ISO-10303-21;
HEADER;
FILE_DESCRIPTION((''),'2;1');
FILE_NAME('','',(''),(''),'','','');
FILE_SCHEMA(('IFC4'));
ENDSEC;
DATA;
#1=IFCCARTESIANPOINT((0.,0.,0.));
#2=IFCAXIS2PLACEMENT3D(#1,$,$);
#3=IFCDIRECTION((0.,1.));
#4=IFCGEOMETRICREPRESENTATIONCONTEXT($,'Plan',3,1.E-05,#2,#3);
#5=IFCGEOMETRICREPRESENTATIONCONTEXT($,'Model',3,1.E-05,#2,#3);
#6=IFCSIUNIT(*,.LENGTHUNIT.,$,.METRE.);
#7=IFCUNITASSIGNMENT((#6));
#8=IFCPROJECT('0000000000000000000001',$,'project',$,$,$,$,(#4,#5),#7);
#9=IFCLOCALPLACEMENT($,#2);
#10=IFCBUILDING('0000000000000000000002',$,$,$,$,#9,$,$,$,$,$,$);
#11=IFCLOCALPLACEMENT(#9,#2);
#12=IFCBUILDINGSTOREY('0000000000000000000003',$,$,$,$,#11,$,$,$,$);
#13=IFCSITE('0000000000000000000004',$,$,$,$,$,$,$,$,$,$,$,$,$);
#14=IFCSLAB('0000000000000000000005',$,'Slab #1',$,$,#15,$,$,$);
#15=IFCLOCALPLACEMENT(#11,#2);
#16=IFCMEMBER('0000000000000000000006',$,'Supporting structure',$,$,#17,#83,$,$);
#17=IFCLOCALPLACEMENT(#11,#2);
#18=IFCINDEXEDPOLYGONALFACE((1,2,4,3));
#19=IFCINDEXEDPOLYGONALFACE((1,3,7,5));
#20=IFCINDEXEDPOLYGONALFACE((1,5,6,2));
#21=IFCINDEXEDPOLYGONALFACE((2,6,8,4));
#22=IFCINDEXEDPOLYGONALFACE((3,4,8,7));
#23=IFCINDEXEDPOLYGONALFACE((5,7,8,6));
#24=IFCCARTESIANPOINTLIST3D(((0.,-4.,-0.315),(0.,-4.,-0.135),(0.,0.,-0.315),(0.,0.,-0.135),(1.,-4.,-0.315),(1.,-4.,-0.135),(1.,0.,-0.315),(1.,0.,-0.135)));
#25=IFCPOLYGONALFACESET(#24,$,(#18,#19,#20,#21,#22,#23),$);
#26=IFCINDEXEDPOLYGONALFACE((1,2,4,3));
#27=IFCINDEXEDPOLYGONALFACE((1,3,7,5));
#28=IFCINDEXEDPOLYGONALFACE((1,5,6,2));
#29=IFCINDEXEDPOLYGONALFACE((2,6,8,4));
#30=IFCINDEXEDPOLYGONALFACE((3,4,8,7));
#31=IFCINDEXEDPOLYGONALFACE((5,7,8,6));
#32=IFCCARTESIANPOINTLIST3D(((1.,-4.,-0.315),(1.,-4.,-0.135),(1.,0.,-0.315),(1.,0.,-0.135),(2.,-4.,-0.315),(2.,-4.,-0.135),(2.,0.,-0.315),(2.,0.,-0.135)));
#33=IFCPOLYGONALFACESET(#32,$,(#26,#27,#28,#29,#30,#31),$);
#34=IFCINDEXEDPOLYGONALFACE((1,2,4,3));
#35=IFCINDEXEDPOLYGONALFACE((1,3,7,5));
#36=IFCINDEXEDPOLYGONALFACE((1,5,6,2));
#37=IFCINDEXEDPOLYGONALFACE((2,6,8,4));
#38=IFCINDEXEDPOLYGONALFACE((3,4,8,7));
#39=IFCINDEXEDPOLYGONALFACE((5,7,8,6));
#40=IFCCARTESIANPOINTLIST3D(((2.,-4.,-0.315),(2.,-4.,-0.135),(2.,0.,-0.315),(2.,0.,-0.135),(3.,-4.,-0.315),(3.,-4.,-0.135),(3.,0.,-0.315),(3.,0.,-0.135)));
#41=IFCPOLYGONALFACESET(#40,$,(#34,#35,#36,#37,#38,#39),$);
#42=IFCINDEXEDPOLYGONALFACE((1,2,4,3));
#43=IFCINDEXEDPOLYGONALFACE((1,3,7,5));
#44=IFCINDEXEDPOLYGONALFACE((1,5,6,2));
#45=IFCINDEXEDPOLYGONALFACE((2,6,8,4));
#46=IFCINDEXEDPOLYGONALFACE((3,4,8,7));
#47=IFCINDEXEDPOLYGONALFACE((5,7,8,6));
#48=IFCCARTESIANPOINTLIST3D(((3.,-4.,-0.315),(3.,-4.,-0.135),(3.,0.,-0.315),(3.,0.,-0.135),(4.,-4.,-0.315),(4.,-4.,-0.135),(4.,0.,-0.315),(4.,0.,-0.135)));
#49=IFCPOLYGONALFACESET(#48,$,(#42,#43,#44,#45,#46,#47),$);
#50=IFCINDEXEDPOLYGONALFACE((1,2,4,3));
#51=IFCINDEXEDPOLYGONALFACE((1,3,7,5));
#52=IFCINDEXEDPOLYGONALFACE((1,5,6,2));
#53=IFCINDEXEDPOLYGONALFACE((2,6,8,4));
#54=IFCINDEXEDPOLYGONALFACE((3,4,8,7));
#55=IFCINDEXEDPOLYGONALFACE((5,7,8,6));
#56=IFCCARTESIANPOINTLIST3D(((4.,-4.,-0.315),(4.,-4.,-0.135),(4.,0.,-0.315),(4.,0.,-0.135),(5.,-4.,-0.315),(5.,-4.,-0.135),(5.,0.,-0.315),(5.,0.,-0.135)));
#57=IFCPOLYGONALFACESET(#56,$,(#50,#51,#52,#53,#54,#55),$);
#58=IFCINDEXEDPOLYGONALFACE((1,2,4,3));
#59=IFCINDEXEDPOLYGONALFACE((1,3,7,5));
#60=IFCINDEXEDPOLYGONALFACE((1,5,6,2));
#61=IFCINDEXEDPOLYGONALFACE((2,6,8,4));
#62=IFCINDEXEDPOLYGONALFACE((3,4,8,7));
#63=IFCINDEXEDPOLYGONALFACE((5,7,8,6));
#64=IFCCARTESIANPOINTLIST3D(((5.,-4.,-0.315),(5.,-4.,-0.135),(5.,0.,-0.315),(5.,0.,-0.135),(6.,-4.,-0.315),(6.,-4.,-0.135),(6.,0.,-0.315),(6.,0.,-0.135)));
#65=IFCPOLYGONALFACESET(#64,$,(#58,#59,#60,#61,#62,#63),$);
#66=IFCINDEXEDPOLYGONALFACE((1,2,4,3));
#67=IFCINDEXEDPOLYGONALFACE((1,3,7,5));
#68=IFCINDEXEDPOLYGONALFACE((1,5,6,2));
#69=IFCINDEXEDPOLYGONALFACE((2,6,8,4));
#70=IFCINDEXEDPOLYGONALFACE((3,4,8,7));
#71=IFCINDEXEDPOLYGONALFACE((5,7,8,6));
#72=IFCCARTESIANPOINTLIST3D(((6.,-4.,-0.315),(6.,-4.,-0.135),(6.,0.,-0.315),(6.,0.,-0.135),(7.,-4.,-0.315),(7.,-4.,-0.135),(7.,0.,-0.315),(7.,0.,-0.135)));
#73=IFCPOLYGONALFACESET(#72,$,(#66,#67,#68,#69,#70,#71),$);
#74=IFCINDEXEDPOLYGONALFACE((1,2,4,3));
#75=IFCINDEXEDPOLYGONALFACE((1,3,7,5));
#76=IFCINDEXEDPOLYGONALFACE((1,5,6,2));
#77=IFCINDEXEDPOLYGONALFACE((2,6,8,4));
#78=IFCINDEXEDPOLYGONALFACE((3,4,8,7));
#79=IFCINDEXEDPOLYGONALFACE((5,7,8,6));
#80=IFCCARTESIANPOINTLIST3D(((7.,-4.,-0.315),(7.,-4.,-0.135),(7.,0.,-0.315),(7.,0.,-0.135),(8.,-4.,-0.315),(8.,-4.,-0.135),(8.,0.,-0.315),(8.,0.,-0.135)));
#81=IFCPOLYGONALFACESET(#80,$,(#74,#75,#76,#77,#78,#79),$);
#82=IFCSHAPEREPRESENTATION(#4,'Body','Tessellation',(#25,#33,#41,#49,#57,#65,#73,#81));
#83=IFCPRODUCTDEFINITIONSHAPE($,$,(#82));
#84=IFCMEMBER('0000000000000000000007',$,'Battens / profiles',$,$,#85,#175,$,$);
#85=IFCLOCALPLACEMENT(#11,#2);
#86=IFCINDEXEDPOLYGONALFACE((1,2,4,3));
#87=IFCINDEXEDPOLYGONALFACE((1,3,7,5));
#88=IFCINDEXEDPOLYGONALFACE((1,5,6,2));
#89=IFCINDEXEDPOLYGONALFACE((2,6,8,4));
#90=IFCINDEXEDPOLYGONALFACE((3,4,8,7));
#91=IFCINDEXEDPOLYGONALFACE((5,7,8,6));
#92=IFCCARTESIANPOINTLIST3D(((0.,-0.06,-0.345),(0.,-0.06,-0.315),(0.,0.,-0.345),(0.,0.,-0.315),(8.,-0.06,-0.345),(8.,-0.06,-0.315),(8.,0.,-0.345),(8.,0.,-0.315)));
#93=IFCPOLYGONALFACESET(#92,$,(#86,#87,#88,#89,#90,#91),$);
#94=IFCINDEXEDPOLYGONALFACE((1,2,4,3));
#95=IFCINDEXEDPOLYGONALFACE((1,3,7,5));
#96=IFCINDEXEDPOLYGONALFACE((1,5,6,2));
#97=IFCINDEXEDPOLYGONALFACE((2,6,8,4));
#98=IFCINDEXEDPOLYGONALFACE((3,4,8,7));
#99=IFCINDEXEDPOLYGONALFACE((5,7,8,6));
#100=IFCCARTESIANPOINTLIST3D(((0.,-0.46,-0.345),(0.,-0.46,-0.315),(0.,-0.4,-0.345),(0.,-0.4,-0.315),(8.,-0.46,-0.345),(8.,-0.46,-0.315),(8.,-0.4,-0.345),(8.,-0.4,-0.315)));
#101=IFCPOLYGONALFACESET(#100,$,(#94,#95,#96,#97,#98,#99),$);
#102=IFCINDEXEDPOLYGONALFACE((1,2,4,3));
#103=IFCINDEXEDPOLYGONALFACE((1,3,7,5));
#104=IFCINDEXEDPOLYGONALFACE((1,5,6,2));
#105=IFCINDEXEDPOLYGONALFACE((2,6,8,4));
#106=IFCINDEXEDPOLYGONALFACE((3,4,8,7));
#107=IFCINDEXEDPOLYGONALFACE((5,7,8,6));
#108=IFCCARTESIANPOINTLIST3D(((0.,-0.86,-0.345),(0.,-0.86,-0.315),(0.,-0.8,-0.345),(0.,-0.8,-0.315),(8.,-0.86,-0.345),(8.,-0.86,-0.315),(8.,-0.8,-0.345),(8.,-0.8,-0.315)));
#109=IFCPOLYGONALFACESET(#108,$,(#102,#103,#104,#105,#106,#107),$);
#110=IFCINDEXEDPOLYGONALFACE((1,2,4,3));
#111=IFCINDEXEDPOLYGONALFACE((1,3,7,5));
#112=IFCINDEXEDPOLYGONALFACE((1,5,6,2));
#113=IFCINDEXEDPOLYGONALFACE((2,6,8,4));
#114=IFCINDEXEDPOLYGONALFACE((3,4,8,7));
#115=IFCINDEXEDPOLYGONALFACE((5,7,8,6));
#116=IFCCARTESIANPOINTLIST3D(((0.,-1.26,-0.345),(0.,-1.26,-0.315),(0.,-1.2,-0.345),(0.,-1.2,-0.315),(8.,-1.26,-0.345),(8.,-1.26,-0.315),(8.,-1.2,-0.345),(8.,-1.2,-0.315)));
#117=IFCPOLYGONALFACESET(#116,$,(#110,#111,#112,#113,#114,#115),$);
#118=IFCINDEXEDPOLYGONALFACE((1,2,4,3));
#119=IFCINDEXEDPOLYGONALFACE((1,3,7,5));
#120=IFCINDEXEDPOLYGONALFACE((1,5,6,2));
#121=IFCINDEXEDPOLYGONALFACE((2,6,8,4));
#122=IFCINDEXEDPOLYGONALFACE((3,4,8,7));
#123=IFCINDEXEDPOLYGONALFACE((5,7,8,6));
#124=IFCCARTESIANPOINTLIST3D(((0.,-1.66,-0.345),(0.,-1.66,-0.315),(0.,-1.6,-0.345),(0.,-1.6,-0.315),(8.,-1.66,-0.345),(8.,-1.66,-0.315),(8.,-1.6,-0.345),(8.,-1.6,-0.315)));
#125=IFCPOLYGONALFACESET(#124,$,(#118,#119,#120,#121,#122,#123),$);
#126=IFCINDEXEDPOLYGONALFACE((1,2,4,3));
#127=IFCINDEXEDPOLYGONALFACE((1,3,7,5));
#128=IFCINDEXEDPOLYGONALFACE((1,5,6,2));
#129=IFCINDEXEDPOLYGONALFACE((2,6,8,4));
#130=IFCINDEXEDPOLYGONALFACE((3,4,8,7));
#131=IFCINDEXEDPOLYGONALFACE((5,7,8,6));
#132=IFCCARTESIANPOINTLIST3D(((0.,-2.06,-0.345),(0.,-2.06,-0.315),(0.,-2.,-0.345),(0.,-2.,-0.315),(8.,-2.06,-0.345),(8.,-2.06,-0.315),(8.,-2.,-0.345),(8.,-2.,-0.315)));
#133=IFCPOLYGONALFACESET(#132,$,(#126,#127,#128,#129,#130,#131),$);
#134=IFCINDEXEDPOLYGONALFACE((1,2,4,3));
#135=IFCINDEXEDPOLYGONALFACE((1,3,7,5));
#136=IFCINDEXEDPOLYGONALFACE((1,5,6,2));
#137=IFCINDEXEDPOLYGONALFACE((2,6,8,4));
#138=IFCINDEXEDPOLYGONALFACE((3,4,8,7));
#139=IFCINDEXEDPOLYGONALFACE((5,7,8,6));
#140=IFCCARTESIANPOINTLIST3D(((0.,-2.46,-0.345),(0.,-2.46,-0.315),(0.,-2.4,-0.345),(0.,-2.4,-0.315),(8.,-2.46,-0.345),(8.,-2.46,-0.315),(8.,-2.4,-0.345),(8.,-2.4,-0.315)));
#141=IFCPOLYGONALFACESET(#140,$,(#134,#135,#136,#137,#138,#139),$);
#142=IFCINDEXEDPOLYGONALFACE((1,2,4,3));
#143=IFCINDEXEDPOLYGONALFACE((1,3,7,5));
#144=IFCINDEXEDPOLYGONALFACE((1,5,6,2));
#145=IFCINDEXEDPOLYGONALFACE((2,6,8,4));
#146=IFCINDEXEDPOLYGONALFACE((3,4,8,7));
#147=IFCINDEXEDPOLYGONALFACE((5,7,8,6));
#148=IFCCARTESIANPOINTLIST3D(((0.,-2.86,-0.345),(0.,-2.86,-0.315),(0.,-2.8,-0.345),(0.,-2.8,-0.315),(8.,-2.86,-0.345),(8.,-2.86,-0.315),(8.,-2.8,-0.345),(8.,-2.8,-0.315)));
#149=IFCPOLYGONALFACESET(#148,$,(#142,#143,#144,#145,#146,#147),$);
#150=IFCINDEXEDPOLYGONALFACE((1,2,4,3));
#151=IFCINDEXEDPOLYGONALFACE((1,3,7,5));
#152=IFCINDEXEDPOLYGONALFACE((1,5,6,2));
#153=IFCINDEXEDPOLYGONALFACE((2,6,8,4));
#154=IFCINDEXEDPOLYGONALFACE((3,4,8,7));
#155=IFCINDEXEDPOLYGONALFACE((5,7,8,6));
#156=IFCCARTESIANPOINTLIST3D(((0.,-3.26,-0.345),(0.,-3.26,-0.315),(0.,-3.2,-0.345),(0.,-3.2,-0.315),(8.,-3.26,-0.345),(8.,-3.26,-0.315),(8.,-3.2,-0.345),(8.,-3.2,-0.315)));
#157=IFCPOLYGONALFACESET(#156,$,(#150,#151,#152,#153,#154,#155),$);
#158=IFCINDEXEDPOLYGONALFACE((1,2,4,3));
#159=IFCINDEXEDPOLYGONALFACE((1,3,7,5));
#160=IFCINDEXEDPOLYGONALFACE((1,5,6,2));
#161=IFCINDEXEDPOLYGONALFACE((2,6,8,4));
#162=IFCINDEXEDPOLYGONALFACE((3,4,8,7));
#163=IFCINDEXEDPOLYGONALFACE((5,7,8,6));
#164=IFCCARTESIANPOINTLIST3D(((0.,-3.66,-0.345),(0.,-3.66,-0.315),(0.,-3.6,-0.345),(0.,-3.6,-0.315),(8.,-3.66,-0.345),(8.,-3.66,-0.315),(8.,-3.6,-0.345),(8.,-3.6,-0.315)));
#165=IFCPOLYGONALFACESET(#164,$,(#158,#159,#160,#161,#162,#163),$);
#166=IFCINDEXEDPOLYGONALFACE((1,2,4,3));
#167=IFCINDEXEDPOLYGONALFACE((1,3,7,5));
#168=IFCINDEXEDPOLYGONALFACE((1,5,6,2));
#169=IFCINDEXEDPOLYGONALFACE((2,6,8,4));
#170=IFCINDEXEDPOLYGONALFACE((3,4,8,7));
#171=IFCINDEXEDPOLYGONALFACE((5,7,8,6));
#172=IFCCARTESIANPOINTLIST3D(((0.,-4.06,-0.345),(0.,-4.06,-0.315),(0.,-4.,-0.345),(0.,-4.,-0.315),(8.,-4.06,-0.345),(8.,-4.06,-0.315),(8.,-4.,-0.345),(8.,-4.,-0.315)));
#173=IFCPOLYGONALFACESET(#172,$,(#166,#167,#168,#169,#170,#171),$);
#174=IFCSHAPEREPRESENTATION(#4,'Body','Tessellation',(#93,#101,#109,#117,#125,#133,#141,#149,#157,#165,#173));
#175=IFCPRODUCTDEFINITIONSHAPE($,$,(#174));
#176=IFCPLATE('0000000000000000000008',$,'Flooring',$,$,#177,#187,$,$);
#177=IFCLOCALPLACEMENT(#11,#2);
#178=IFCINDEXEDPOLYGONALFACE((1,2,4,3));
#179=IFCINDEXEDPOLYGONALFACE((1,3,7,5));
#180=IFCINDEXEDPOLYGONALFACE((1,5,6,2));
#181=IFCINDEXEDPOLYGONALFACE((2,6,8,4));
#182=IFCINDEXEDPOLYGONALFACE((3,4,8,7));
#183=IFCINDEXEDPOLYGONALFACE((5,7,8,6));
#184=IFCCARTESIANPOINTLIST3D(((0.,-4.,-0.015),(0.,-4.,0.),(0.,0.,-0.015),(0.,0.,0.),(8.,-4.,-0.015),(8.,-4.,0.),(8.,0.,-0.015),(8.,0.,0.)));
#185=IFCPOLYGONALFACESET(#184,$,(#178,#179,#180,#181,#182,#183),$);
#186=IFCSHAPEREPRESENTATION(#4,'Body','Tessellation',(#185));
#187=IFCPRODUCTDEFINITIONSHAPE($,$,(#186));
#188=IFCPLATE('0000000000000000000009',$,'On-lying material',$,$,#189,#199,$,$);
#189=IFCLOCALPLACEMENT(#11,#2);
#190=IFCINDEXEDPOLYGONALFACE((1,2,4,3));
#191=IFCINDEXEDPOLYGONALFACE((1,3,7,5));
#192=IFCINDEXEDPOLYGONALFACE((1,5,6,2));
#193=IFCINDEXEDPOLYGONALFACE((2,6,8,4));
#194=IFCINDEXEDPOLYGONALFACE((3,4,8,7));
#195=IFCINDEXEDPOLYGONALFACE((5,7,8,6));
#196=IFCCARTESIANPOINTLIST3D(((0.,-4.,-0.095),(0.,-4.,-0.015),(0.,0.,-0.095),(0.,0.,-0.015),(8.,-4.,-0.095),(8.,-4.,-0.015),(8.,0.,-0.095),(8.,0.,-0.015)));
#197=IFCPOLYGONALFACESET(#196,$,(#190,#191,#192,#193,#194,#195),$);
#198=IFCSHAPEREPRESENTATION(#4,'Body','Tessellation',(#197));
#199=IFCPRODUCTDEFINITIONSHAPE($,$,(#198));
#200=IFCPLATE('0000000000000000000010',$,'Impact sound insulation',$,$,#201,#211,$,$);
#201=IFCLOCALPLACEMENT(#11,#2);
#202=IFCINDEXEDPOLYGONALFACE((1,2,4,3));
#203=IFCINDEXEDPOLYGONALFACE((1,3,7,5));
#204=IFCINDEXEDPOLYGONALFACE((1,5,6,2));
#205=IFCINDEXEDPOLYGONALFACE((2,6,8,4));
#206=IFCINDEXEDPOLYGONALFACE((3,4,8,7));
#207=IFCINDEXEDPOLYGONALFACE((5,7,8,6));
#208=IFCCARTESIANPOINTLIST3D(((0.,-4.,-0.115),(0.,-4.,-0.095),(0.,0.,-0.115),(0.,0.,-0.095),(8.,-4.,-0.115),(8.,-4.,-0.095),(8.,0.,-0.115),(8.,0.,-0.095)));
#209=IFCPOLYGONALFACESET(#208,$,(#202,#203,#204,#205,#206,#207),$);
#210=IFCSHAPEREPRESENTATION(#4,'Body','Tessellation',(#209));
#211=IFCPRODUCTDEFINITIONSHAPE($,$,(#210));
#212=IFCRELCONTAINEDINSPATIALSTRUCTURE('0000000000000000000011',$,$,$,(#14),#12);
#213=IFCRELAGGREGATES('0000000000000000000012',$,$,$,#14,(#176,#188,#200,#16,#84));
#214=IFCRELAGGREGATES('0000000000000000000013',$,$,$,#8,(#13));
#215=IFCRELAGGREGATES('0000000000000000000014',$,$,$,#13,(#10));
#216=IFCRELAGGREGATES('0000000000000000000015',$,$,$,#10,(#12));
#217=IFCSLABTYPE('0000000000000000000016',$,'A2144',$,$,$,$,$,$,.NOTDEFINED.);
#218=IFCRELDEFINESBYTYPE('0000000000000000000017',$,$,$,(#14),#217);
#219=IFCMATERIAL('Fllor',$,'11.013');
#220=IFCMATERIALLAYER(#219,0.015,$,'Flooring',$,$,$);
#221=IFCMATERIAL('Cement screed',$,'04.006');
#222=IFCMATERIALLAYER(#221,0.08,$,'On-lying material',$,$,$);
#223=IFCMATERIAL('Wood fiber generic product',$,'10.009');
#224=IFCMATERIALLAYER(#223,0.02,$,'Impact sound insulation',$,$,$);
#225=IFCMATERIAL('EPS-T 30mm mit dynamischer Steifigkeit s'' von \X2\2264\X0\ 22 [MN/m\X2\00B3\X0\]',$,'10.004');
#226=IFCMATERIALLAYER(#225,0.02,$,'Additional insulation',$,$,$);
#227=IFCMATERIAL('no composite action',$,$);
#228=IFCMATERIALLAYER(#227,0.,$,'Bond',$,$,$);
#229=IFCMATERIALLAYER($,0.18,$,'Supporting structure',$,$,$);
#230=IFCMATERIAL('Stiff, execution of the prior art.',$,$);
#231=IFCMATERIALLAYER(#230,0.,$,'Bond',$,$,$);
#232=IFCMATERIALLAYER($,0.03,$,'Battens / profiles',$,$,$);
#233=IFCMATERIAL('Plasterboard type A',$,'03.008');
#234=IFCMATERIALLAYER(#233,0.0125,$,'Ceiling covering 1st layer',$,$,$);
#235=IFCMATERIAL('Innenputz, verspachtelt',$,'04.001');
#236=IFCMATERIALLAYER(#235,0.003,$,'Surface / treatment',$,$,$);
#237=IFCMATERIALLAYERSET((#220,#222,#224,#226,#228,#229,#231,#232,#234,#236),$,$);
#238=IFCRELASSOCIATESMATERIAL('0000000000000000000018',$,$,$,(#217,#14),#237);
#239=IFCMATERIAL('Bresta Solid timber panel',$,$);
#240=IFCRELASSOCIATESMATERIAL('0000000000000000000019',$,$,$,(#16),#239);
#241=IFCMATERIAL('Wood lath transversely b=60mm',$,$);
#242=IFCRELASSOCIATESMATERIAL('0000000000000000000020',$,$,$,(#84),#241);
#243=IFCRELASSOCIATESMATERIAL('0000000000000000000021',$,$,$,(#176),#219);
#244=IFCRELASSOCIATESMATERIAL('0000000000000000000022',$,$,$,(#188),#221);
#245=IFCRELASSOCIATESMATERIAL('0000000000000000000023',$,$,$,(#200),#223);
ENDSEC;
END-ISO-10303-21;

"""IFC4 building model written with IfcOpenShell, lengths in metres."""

from ifc_helpers import new_model, si_unit, direction, frame, frame_2d, origin, origin_with_axes, place, context, project, spatial, rectangle, extrude, material, layer, layer_set, type_object, element, aggregate, save


model = new_model("IFC4")

# Units and contexts
plan_context = context("Plan", 3, precision=1e-05, world=origin(), true_north=direction((0.0, 1.0)))
model_context = context("Model", 3, precision=1e-05, world=origin(), true_north=direction((0.0, 1.0)))
ifc_project = project(units=[si_unit("LENGTHUNIT", "METRE")], contexts=[plan_context, model_context])

# Site, building, storey
site = spatial("IfcSite", under=ifc_project)
building_placement = place(None, origin())
building = spatial("IfcBuilding", under=site, at=building_placement)
storey_placement = place(building_placement, origin())
storey = spatial("IfcBuildingStorey", under=building, at=storey_placement)

# Slab, members, plates
ifc_material_1 = material(Name="Fllor", Category="11.013")
ifc_layer_1 = layer(ifc_material_1, 0.015, Name="Flooring")
ifc_material_2 = material(Name="Cement screed", Category="04.006")
ifc_layer_2 = layer(ifc_material_2, 0.08, Name="On-lying material")
ifc_material_3 = material(Name="Wood fiber generic product", Category="10.009")
ifc_layer_3 = layer(ifc_material_3, 0.02, Name="Impact sound insulation")
ifc_material_4 = material(Name="EPS-T 30mm mit dynamischer Steifigkeit s' von ≤ 22 [MN/m³]", Category="10.004")
ifc_layer_4 = layer(ifc_material_4, 0.02, Name="Additional insulation")
ifc_material_5 = material(Name="no composite action")
ifc_layer_5 = layer(ifc_material_5, 0.0, Name="Bond")
ifc_layer_6 = layer(None, 0.18, Name="Supporting structure")
ifc_material_6 = material(Name="Stiff, execution of the prior art.")
ifc_layer_7 = layer(ifc_material_6, 0.0, Name="Bond")
ifc_layer_8 = layer(None, 0.03, Name="Battens / profiles")
ifc_material_7 = material(Name="Plasterboard type A", Category="03.008")
ifc_layer_9 = layer(ifc_material_7, 0.0125, Name="Ceiling covering 1st layer")
ifc_material_8 = material(Name="Innenputz, verspachtelt", Category="04.001")
ifc_layer_10 = layer(ifc_material_8, 0.003, Name="Surface / treatment")
ifc_layer_set = layer_set([ifc_layer_1, ifc_layer_2, ifc_layer_3, ifc_layer_4, ifc_layer_5, ifc_layer_6, ifc_layer_7, ifc_layer_8, ifc_layer_9, ifc_layer_10])
slab_type = type_object("IfcSlabType", Name="A2144", PredefinedType="NOTDEFINED", material=ifc_layer_set)
slab_placement = place(None, frame((0.0, 0.0, 0.0), z_axis=(0.0, 0.0, -1.0), x_axis=(1.0, 0.0, 0.0)))
slab = element("IfcSlab", 1, at=slab_placement, inside=storey, type_object=slab_type, material=ifc_layer_set, Name="Slab #1")
ifc_material_9 = material(Name="Bresta Solid timber panel")
member_1_placement = place(slab_placement, origin())
member_1 = element("IfcMember", 2, at=member_1_placement, material=ifc_material_9, Name="Supporting structure", context=plan_context, shape_type="SweptSolid", body=[
    extrude(rectangle(XDim=1.0, YDim=0.18, at=frame_2d((0.5, 0.09), x_axis=(1.0, 0.0))), frame((0.0, 4.0, 0.135), z_axis=(0.0, -1.0, 0.0), x_axis=(1.0, 0.0, 0.0)), (0.0, 0.0, 1.0), 4.0),
    extrude(rectangle(XDim=1.0, YDim=0.18, at=frame_2d((0.5, 0.09), x_axis=(1.0, 0.0))), frame((1.0, 4.0, 0.135), z_axis=(0.0, -1.0, 0.0), x_axis=(1.0, 0.0, 0.0)), (0.0, 0.0, 1.0), 4.0),
    extrude(rectangle(XDim=1.0, YDim=0.18, at=frame_2d((0.5, 0.09), x_axis=(1.0, 0.0))), frame((2.0, 4.0, 0.135), z_axis=(0.0, -1.0, 0.0), x_axis=(1.0, 0.0, 0.0)), (0.0, 0.0, 1.0), 4.0),
    extrude(rectangle(XDim=1.0, YDim=0.18, at=frame_2d((0.5, 0.09), x_axis=(1.0, 0.0))), frame((3.0, 4.0, 0.135), z_axis=(0.0, -1.0, 0.0), x_axis=(1.0, 0.0, 0.0)), (0.0, 0.0, 1.0), 4.0),
    extrude(rectangle(XDim=1.0, YDim=0.18, at=frame_2d((0.5, 0.09), x_axis=(1.0, 0.0))), frame((4.0, 4.0, 0.135), z_axis=(0.0, -1.0, 0.0), x_axis=(1.0, 0.0, 0.0)), (0.0, 0.0, 1.0), 4.0),
    extrude(rectangle(XDim=1.0, YDim=0.18, at=frame_2d((0.5, 0.09), x_axis=(1.0, 0.0))), frame((5.0, 4.0, 0.135), z_axis=(0.0, -1.0, 0.0), x_axis=(1.0, 0.0, 0.0)), (0.0, 0.0, 1.0), 4.0),
    extrude(rectangle(XDim=1.0, YDim=0.18, at=frame_2d((0.5, 0.09), x_axis=(1.0, 0.0))), frame((6.0, 4.0, 0.135), z_axis=(0.0, -1.0, 0.0), x_axis=(1.0, 0.0, 0.0)), (0.0, 0.0, 1.0), 4.0),
    extrude(rectangle(XDim=1.0, YDim=0.18, at=frame_2d((0.5, 0.09), x_axis=(1.0, 0.0))), frame((7.0, 4.0, 0.135), z_axis=(0.0, -1.0, 0.0), x_axis=(1.0, 0.0, 0.0)), (0.0, 0.0, 1.0), 4.0),
])
ifc_material_10 = material(Name="Wood lath transversely b=60mm")
member_2_placement = place(slab_placement, origin())
member_2 = element("IfcMember", 3, at=member_2_placement, material=ifc_material_10, Name="Battens / profiles", context=plan_context, shape_type="SweptSolid", body=[
    extrude(rectangle(XDim=0.06, YDim=0.03, at=frame_2d((0.03, 0.015), x_axis=(1.0, 0.0))), frame((0.0, 0.0, 0.315), z_axis=(1.0, 0.0, 0.0), x_axis=(0.0, 1.0, 0.0)), (0.0, 0.0, 1.0), 8.0),
    extrude(rectangle(XDim=0.06, YDim=0.03, at=frame_2d((0.03, 0.015), x_axis=(1.0, 0.0))), frame((0.0, 0.4, 0.315), z_axis=(1.0, 0.0, 0.0), x_axis=(0.0, 1.0, 0.0)), (0.0, 0.0, 1.0), 8.0),
    extrude(rectangle(XDim=0.06, YDim=0.03, at=frame_2d((0.03, 0.015), x_axis=(1.0, 0.0))), frame((0.0, 0.8, 0.315), z_axis=(1.0, 0.0, 0.0), x_axis=(0.0, 1.0, 0.0)), (0.0, 0.0, 1.0), 8.0),
    extrude(rectangle(XDim=0.06, YDim=0.03, at=frame_2d((0.03, 0.015), x_axis=(1.0, 0.0))), frame((0.0, 1.2, 0.315), z_axis=(1.0, 0.0, 0.0), x_axis=(0.0, 1.0, 0.0)), (0.0, 0.0, 1.0), 8.0),
    extrude(rectangle(XDim=0.06, YDim=0.03, at=frame_2d((0.03, 0.015), x_axis=(1.0, 0.0))), frame((0.0, 1.6, 0.315), z_axis=(1.0, 0.0, 0.0), x_axis=(0.0, 1.0, 0.0)), (0.0, 0.0, 1.0), 8.0),
    extrude(rectangle(XDim=0.06, YDim=0.03, at=frame_2d((0.03, 0.015), x_axis=(1.0, 0.0))), frame((0.0, 2.0, 0.315), z_axis=(1.0, 0.0, 0.0), x_axis=(0.0, 1.0, 0.0)), (0.0, 0.0, 1.0), 8.0),
    extrude(rectangle(XDim=0.06, YDim=0.03, at=frame_2d((0.03, 0.015), x_axis=(1.0, 0.0))), frame((0.0, 2.4, 0.315), z_axis=(1.0, 0.0, 0.0), x_axis=(0.0, 1.0, 0.0)), (0.0, 0.0, 1.0), 8.0),
    extrude(rectangle(XDim=0.06, YDim=0.03, at=frame_2d((0.03, 0.015), x_axis=(1.0, 0.0))), frame((0.0, 2.8, 0.315), z_axis=(1.0, 0.0, 0.0), x_axis=(0.0, 1.0, 0.0)), (0.0, 0.0, 1.0), 8.0),
    extrude(rectangle(XDim=0.06, YDim=0.03, at=frame_2d((0.03, 0.015), x_axis=(1.0, 0.0))), frame((0.0, 3.2, 0.315), z_axis=(1.0, 0.0, 0.0), x_axis=(0.0, 1.0, 0.0)), (0.0, 0.0, 1.0), 8.0),
    extrude(rectangle(XDim=0.06, YDim=0.03, at=frame_2d((0.03, 0.015), x_axis=(1.0, 0.0))), frame((0.0, 3.6, 0.315), z_axis=(1.0, 0.0, 0.0), x_axis=(0.0, 1.0, 0.0)), (0.0, 0.0, 1.0), 8.0),
    extrude(rectangle(XDim=0.06, YDim=0.03, at=frame_2d((0.03, 0.015), x_axis=(1.0, 0.0))), frame((0.0, 4.0, 0.315), z_axis=(1.0, 0.0, 0.0), x_axis=(0.0, 1.0, 0.0)), (0.0, 0.0, 1.0), 8.0),
])
plate_1_placement = place(slab_placement, origin())
plate_1 = element("IfcPlate", 4, at=plate_1_placement, material=ifc_material_1, Name="Flooring", context=plan_context, shape_type="SweptSolid", body=[
    extrude(rectangle(XDim=8.0, YDim=4.0, at=frame_2d((4.0, 2.0), x_axis=(1.0, 0.0))), origin_with_axes(), (0.0, 0.0, 1.0), 0.015),
])
plate_2_placement = place(slab_placement, origin())
plate_2 = element("IfcPlate", 5, at=plate_2_placement, material=ifc_material_2, Name="On-lying material", context=plan_context, shape_type="SweptSolid", body=[
    extrude(rectangle(XDim=8.0, YDim=4.0, at=frame_2d((4.0, 2.0), x_axis=(1.0, 0.0))), frame((0.0, 0.0, 0.015), z_axis=(0.0, 0.0, 1.0), x_axis=(1.0, 0.0, 0.0)), (0.0, 0.0, 1.0), 0.08),
])
plate_3_placement = place(slab_placement, origin())
plate_3 = element("IfcPlate", 6, at=plate_3_placement, material=ifc_material_3, Name="Impact sound insulation", context=plan_context, shape_type="SweptSolid", body=[
    extrude(rectangle(XDim=8.0, YDim=4.0, at=frame_2d((4.0, 2.0), x_axis=(1.0, 0.0))), frame((0.0, 0.0, 0.095), z_axis=(0.0, 0.0, 1.0), x_axis=(1.0, 0.0, 0.0)), (0.0, 0.0, 1.0), 0.02),
])
aggregate(slab, [plate_1, plate_2, plate_3, member_1, member_2])

save(model, "model.ifc")
